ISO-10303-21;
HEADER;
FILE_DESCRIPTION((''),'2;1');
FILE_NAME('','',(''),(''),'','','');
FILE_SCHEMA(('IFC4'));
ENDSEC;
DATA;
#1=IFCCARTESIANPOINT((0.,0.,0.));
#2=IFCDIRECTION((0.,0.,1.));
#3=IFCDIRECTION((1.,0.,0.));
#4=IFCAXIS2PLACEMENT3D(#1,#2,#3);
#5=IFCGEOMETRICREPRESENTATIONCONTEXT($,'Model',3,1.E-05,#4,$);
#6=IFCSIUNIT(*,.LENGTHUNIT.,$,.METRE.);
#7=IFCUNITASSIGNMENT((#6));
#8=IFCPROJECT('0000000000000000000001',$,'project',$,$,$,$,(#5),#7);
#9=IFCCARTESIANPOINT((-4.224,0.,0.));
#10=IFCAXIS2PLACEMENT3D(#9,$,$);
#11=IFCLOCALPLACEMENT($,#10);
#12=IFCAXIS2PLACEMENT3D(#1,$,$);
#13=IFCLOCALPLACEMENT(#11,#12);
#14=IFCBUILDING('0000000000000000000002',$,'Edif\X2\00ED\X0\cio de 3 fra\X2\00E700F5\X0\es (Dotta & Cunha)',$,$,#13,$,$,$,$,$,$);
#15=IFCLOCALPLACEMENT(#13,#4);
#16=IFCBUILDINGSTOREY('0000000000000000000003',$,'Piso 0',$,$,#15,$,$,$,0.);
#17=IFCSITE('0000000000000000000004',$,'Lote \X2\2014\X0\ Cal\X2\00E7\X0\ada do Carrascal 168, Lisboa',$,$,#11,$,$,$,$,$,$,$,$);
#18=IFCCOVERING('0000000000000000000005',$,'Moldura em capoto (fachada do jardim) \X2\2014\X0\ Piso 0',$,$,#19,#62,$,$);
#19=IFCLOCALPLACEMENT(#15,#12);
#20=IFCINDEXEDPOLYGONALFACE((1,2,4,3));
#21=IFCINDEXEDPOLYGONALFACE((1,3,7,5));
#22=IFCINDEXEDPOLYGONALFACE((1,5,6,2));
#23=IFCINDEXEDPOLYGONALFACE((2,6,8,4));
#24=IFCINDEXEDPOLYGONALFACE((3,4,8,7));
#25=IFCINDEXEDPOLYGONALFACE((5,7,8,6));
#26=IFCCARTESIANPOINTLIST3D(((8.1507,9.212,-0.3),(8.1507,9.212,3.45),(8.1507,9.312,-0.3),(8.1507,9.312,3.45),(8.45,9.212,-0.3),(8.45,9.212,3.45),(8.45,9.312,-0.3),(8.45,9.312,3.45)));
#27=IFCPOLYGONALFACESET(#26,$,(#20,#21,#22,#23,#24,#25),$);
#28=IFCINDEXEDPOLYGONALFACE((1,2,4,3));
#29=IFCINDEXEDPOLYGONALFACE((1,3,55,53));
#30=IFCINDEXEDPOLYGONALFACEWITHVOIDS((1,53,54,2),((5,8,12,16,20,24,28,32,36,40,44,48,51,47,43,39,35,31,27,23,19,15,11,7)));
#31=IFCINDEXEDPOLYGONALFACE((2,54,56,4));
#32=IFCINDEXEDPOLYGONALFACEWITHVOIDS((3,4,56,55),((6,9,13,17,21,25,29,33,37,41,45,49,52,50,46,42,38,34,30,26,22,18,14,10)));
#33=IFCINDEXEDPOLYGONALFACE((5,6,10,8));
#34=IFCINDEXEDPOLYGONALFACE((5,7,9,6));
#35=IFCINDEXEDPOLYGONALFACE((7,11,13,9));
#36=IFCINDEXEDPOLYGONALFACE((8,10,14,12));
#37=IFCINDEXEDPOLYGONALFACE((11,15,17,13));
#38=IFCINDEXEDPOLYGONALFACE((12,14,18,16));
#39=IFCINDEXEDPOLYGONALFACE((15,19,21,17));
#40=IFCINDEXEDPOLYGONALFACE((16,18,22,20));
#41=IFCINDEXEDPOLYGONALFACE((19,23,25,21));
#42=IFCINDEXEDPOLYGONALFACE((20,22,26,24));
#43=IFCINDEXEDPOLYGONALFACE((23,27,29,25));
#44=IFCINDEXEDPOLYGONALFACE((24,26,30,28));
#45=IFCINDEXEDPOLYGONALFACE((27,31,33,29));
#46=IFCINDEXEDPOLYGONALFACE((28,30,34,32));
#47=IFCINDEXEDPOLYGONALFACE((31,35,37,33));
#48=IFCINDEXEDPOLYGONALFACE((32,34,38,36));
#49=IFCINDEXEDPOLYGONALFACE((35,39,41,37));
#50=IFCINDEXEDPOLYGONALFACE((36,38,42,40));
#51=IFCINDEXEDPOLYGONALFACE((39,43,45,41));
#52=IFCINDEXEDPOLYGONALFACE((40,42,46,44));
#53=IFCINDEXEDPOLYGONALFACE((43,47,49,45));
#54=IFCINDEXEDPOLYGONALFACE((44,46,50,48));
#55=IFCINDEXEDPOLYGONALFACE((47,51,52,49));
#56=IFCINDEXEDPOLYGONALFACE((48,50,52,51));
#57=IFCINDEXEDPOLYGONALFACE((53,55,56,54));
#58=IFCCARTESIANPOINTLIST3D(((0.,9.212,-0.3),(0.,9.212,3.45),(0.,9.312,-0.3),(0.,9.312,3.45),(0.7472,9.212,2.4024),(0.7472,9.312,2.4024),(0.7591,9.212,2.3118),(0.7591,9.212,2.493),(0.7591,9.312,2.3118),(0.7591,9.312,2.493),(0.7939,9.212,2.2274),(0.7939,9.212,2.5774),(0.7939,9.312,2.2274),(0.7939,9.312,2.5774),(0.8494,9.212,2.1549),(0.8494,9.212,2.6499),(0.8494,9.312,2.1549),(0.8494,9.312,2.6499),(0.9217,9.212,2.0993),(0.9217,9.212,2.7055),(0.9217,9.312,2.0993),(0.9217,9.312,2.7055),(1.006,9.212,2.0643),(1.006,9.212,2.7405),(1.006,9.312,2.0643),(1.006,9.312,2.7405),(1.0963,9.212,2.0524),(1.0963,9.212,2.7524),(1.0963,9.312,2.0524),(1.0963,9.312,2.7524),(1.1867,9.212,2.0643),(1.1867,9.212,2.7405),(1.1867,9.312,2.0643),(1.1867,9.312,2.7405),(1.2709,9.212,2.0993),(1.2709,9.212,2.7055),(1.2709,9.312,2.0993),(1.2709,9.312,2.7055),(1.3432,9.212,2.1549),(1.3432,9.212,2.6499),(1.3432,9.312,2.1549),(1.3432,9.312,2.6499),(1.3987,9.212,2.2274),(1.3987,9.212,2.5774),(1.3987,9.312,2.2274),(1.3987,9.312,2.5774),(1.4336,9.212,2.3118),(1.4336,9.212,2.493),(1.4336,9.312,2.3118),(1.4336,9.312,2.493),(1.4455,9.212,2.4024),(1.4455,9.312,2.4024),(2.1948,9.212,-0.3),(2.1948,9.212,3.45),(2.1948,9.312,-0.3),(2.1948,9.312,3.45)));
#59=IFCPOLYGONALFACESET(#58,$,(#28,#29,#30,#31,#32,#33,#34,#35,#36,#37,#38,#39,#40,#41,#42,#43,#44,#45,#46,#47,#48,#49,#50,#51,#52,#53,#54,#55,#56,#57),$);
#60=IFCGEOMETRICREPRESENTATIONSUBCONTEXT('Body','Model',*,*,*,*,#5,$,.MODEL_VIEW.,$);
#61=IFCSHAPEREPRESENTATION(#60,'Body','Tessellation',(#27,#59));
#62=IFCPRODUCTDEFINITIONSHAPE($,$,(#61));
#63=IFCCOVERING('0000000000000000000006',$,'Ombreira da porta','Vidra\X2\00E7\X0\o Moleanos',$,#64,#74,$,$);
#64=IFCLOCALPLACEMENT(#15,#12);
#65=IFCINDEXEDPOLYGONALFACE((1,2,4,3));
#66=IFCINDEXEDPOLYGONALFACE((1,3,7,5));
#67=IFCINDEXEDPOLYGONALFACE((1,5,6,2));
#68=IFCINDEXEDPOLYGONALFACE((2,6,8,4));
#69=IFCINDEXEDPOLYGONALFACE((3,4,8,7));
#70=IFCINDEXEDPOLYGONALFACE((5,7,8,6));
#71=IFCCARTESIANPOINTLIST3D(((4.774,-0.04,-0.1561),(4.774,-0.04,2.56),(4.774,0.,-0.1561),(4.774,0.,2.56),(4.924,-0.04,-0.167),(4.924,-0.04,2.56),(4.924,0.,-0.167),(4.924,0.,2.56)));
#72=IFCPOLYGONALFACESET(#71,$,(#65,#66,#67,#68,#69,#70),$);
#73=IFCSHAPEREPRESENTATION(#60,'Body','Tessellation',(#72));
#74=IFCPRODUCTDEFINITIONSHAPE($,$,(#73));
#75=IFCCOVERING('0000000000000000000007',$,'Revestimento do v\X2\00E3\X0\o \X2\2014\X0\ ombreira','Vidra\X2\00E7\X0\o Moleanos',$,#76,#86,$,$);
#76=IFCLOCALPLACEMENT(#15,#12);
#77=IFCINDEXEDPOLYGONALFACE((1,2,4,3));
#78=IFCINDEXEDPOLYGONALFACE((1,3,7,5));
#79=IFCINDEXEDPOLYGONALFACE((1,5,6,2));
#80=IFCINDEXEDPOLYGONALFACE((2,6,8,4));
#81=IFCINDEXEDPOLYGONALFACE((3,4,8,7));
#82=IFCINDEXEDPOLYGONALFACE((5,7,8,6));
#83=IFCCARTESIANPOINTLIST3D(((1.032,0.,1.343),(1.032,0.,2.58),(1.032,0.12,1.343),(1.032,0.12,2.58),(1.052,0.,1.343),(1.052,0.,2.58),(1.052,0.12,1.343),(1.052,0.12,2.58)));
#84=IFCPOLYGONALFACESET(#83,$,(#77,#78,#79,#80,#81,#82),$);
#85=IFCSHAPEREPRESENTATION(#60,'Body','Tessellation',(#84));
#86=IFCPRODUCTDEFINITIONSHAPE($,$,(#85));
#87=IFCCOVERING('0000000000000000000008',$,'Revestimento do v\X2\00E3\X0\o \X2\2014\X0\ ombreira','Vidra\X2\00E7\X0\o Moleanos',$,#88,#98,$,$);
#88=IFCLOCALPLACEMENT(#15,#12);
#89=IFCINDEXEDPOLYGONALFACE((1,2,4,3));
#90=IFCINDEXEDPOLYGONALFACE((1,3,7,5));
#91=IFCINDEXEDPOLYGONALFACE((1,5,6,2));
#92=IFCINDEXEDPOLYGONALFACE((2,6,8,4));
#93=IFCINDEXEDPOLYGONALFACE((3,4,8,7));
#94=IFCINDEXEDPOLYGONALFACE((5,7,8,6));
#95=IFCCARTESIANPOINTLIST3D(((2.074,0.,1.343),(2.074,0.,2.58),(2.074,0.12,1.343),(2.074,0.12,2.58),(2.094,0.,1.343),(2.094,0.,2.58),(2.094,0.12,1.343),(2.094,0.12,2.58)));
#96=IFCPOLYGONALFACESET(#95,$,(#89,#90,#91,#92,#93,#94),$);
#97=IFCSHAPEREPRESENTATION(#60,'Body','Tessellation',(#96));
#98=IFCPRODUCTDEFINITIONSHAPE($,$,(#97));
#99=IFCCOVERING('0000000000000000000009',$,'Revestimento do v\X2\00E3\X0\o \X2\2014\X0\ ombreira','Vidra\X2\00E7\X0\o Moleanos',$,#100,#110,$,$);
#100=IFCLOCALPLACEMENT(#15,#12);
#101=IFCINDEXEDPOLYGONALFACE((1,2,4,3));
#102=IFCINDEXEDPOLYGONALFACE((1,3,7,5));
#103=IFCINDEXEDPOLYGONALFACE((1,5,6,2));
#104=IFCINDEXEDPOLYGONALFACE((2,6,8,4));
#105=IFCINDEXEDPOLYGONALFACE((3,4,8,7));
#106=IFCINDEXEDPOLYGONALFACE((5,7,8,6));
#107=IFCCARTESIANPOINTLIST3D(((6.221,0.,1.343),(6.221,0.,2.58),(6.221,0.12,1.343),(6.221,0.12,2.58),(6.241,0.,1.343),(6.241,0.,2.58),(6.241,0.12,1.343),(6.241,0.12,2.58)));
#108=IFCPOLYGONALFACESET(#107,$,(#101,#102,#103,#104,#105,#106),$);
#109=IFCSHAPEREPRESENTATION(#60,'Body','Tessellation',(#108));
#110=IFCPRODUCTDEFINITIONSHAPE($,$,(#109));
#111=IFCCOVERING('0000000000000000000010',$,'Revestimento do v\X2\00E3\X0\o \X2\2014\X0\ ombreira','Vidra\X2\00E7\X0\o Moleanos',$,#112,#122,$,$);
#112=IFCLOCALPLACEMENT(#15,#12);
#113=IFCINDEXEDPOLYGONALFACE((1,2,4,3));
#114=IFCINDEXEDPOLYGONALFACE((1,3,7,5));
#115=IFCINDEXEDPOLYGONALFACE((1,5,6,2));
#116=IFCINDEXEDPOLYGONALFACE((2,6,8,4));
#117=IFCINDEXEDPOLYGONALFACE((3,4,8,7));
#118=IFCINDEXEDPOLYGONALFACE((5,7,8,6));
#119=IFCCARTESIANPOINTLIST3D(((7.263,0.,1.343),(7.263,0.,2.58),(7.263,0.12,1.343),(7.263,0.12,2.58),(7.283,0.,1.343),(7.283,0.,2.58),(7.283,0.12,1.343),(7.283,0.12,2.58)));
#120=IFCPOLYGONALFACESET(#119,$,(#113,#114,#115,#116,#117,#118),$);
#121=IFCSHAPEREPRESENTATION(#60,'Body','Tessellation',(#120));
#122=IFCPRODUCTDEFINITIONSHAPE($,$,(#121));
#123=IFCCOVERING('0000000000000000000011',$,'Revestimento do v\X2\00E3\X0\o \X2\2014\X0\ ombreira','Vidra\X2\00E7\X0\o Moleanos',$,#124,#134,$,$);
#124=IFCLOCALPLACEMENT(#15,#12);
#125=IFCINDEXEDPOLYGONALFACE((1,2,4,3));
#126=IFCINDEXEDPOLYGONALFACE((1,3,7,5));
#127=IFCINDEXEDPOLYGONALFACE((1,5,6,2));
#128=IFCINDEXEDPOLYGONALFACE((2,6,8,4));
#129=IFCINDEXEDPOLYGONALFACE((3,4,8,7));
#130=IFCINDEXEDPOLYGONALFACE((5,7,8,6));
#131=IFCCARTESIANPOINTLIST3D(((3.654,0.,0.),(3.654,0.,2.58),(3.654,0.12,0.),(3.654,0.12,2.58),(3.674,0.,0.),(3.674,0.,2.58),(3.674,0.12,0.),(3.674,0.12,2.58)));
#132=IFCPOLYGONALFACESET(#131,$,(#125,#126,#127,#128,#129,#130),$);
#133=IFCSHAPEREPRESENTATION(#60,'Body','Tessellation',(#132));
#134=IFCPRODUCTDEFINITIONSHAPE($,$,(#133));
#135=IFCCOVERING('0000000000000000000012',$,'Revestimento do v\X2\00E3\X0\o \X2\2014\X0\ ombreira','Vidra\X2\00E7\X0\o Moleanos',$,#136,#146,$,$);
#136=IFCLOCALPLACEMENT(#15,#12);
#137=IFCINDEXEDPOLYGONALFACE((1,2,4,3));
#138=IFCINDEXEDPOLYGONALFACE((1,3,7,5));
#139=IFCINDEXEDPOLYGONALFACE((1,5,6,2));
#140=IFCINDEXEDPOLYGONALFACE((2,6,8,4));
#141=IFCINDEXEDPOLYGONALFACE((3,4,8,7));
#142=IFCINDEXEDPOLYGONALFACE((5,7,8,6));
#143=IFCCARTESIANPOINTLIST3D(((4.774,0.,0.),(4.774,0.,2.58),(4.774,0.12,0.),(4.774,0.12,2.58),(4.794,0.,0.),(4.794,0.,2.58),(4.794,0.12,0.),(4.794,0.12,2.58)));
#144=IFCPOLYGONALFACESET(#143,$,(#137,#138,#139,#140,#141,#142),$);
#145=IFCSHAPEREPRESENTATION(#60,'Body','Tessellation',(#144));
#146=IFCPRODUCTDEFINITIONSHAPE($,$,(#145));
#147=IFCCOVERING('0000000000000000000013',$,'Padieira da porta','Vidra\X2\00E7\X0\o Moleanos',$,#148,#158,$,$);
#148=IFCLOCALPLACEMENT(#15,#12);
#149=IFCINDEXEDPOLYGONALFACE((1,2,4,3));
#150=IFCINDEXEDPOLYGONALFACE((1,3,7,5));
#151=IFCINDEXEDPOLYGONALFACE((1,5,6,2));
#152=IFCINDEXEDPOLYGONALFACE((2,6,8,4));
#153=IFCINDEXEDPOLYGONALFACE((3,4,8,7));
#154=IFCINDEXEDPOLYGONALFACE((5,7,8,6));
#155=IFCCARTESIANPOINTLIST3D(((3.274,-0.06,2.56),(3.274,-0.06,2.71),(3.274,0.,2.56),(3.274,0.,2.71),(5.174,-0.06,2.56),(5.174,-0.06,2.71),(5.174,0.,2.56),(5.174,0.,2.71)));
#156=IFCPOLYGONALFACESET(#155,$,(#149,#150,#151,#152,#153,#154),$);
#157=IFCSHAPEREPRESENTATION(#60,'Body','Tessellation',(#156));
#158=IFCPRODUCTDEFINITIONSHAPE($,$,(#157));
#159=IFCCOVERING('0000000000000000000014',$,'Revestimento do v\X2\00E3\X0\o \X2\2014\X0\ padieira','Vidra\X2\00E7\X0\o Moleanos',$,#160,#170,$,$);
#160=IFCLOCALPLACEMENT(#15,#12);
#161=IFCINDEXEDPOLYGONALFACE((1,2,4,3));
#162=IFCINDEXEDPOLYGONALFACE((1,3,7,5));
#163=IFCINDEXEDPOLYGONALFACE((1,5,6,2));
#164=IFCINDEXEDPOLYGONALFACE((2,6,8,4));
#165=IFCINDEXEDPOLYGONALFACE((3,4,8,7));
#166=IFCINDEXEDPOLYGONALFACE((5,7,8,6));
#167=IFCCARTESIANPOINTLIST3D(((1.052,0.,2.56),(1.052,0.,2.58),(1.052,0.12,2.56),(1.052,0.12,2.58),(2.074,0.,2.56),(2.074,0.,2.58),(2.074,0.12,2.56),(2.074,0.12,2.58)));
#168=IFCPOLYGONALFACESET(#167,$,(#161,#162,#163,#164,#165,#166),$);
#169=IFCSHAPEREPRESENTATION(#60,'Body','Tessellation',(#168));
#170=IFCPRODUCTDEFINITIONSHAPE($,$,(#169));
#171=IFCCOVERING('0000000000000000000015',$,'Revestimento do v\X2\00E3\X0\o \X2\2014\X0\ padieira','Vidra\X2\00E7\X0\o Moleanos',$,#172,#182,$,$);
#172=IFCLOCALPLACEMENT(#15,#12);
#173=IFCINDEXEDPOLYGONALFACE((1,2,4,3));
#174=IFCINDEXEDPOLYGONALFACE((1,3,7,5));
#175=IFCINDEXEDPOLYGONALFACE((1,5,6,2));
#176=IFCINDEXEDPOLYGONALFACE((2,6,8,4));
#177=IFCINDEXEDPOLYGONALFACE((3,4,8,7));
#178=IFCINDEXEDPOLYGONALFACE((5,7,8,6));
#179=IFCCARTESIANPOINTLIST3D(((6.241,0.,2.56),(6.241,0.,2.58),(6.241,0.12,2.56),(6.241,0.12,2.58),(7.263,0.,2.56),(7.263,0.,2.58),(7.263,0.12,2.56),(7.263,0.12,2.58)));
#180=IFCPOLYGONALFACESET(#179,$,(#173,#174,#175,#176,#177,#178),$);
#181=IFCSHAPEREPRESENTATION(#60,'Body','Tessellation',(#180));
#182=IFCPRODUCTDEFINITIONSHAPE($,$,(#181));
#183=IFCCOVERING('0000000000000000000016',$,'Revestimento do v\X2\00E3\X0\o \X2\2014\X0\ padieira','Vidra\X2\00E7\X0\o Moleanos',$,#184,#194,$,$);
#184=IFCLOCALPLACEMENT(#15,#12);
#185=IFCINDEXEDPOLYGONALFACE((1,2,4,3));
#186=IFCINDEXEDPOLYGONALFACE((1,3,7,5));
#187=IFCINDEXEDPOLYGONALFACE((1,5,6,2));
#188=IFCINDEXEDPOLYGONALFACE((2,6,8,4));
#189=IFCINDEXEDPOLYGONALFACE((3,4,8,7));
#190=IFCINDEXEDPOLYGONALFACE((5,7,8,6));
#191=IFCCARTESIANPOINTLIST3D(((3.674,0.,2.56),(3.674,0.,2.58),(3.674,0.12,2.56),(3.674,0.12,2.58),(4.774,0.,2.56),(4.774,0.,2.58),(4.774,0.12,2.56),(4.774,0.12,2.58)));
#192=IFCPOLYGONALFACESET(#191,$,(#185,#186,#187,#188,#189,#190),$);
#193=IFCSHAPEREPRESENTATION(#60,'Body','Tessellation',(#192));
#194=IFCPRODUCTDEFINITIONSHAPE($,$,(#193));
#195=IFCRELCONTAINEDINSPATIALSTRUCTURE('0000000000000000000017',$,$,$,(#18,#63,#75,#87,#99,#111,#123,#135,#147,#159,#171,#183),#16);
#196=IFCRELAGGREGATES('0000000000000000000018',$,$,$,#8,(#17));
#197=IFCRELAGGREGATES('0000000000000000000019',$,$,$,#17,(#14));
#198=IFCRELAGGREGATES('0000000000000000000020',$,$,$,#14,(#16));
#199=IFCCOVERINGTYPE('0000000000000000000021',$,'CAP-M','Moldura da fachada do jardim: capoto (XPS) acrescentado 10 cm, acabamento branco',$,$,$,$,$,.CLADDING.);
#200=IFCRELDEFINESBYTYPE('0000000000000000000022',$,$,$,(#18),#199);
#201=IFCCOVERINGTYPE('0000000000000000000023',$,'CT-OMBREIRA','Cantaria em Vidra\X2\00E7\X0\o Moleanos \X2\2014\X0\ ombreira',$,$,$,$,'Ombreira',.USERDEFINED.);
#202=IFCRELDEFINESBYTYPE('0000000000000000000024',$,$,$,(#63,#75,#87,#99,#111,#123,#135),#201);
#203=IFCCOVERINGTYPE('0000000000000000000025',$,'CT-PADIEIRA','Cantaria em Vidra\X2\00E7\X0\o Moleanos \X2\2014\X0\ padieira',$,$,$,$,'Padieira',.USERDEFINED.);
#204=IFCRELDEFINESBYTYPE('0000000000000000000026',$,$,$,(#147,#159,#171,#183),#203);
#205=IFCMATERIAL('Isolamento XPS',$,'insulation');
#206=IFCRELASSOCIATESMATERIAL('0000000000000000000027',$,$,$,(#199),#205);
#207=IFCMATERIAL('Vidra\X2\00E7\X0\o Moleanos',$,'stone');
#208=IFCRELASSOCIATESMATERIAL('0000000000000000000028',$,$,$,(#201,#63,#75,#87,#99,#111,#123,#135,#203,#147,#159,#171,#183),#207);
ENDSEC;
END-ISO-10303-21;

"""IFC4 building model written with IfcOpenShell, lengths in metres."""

from ifc_helpers import new_model, si_unit, frame, origin, origin_with_axes, place, context, subcontext, project, spatial, line, indexed_curve, outline, extrude, material, type_object, element, save


model = new_model("IFC4")

# Units and contexts
model_context = context("Model", 3, precision=1e-05, world=origin_with_axes())
body_context = subcontext(model_context, "Body", "Model", "MODEL_VIEW")
ifc_project = project(units=[si_unit("LENGTHUNIT", "METRE")], contexts=[model_context])

# Site, building, storey
site_placement = place(None, frame((-4.224, 0.0, 0.0)))
site = spatial("IfcSite", under=ifc_project, at=site_placement, Name="Lote — Calçada do Carrascal 168, Lisboa")
building_placement = place(site_placement, origin())
building = spatial("IfcBuilding", under=site, at=building_placement, Name="Edifício de 3 frações (Dotta & Cunha)")
storey_placement = place(building_placement, origin_with_axes())
storey = spatial("IfcBuildingStorey", under=building, at=storey_placement, Name="Piso 0", Elevation=0.0)

# Covering
ifc_material_1 = material(Name="Isolamento XPS", Category="insulation")
covering_type_1 = type_object("IfcCoveringType", Name="CAP-M", Description="Moldura da fachada do jardim: capoto (XPS) acrescentado 10 cm, acabamento branco", PredefinedType="CLADDING", material=ifc_material_1)
covering_1_placement = place(storey_placement, frame((0.0, 9.312, 0.0), z_axis=(0.0, -1.0, 0.0), x_axis=(1.0, 0.0, 0.0)))
element("IfcCovering", 1, at=covering_1_placement, inside=storey, type_object=covering_type_1, Name="Moldura em capoto (fachada do jardim) — Piso 0", context=body_context, shape_type="SweptSolid", body=[
    extrude(outline(indexed_curve([(8.45, -0.3), (8.1507, -0.3), (8.1507, 3.45), (8.45, 3.45)], segments=[line(1, 2, 3, 4, 1)])), origin_with_axes(), (0.0, 0.0, 1.0), 0.1),
    extrude(outline(indexed_curve([(2.1948, -0.3), (0.0, -0.3), (0.0, 3.45), (2.1948, 3.45)], segments=[line(1, 2, 3, 4, 1)]), holes=[indexed_curve([(0.9217, 2.7055), (0.8494, 2.6499), (0.7939, 2.5774), (0.7591, 2.493), (0.7472, 2.4024), (0.7591, 2.3118), (0.7939, 2.2274), (0.8494, 2.1549), (0.9217, 2.0993), (1.006, 2.0643), (1.0963, 2.0524), (1.1867, 2.0643), (1.2709, 2.0993), (1.3432, 2.1549), (1.3987, 2.2274), (1.4336, 2.3118), (1.4455, 2.4024), (1.4336, 2.493), (1.3987, 2.5774), (1.3432, 2.6499), (1.2709, 2.7055), (1.1867, 2.7405), (1.0963, 2.7524), (1.006, 2.7405)], segments=[line(1, 2, 3, 4, 5, 6, 7, 8, 9, 10, 11, 12, 13, 14, 15, 16, 17, 18, 19, 20, 21, 22, 23, 24, 1)])]), origin_with_axes(), (0.0, 0.0, 1.0), 0.1),
])

# Coverings
ifc_material_2 = material(Name="Vidraço Moleanos", Category="stone")
covering_type_2 = type_object("IfcCoveringType", Name="CT-OMBREIRA", Description="Cantaria em Vidraço Moleanos — ombreira", ElementType="Ombreira", PredefinedType="USERDEFINED", material=ifc_material_2)
covering_2_placement = place(storey_placement, frame((0.0, 0.0, 0.0), z_axis=(0.0, -1.0, 0.0), x_axis=(1.0, 0.0, 0.0)))
element("IfcCovering", 2, at=covering_2_placement, inside=storey, type_object=covering_type_2, material=ifc_material_2, Name="Ombreira da porta", Description="Vidraço Moleanos", context=body_context, shape_type="SweptSolid", body=[
    extrude(outline(indexed_curve([(4.774, -0.1561), (4.924, -0.167), (4.924, 2.56), (4.774, 2.56)], segments=[line(1, 2, 3, 4, 1)])), origin_with_axes(), (0.0, 0.0, 1.0), 0.04),
])
covering_3_placement = place(storey_placement, frame((0.0, 0.12, 0.0), z_axis=(0.0, -1.0, 0.0), x_axis=(1.0, 0.0, 0.0)))
element("IfcCovering", 3, at=covering_3_placement, inside=storey, type_object=covering_type_2, material=ifc_material_2, Name="Revestimento do vão — ombreira", Description="Vidraço Moleanos", context=body_context, shape_type="SweptSolid", body=[
    extrude(outline(indexed_curve([(1.052, 1.343), (1.052, 2.58), (1.032, 2.58), (1.032, 1.343)], segments=[line(1, 2, 3, 4, 1)])), origin_with_axes(), (0.0, 0.0, 1.0), 0.12),
])
covering_4_placement = place(storey_placement, frame((0.0, 0.12, 0.0), z_axis=(0.0, -1.0, 0.0), x_axis=(1.0, 0.0, 0.0)))
element("IfcCovering", 4, at=covering_4_placement, inside=storey, type_object=covering_type_2, material=ifc_material_2, Name="Revestimento do vão — ombreira", Description="Vidraço Moleanos", context=body_context, shape_type="SweptSolid", body=[
    extrude(outline(indexed_curve([(2.094, 1.343), (2.094, 2.58), (2.074, 2.58), (2.074, 1.343)], segments=[line(1, 2, 3, 4, 1)])), origin_with_axes(), (0.0, 0.0, 1.0), 0.12),
])
covering_5_placement = place(storey_placement, frame((0.0, 0.12, 0.0), z_axis=(0.0, -1.0, 0.0), x_axis=(1.0, 0.0, 0.0)))
element("IfcCovering", 5, at=covering_5_placement, inside=storey, type_object=covering_type_2, material=ifc_material_2, Name="Revestimento do vão — ombreira", Description="Vidraço Moleanos", context=body_context, shape_type="SweptSolid", body=[
    extrude(outline(indexed_curve([(6.241, 1.343), (6.241, 2.58), (6.221, 2.58), (6.221, 1.343)], segments=[line(1, 2, 3, 4, 1)])), origin_with_axes(), (0.0, 0.0, 1.0), 0.12),
])
covering_6_placement = place(storey_placement, frame((0.0, 0.12, 0.0), z_axis=(0.0, -1.0, 0.0), x_axis=(1.0, 0.0, 0.0)))
element("IfcCovering", 6, at=covering_6_placement, inside=storey, type_object=covering_type_2, material=ifc_material_2, Name="Revestimento do vão — ombreira", Description="Vidraço Moleanos", context=body_context, shape_type="SweptSolid", body=[
    extrude(outline(indexed_curve([(7.283, 1.343), (7.283, 2.58), (7.263, 2.58), (7.263, 1.343)], segments=[line(1, 2, 3, 4, 1)])), origin_with_axes(), (0.0, 0.0, 1.0), 0.12),
])
covering_7_placement = place(storey_placement, frame((0.0, 0.12, 0.0), z_axis=(0.0, -1.0, 0.0), x_axis=(1.0, 0.0, 0.0)))
element("IfcCovering", 7, at=covering_7_placement, inside=storey, type_object=covering_type_2, material=ifc_material_2, Name="Revestimento do vão — ombreira", Description="Vidraço Moleanos", context=body_context, shape_type="SweptSolid", body=[
    extrude(outline(indexed_curve([(3.674, 0.0), (3.674, 2.58), (3.654, 2.58), (3.654, 0.0)], segments=[line(1, 2, 3, 4, 1)])), origin_with_axes(), (0.0, 0.0, 1.0), 0.12),
])
covering_8_placement = place(storey_placement, frame((0.0, 0.12, 0.0), z_axis=(0.0, -1.0, 0.0), x_axis=(1.0, 0.0, 0.0)))
element("IfcCovering", 8, at=covering_8_placement, inside=storey, type_object=covering_type_2, material=ifc_material_2, Name="Revestimento do vão — ombreira", Description="Vidraço Moleanos", context=body_context, shape_type="SweptSolid", body=[
    extrude(outline(indexed_curve([(4.794, 0.0), (4.794, 2.58), (4.774, 2.58), (4.774, 0.0)], segments=[line(1, 2, 3, 4, 1)])), origin_with_axes(), (0.0, 0.0, 1.0), 0.12),
])
covering_type_3 = type_object("IfcCoveringType", Name="CT-PADIEIRA", Description="Cantaria em Vidraço Moleanos — padieira", ElementType="Padieira", PredefinedType="USERDEFINED", material=ifc_material_2)
covering_9_placement = place(storey_placement, frame((0.0, 0.0, 0.0), z_axis=(0.0, -1.0, 0.0), x_axis=(1.0, 0.0, 0.0)))
element("IfcCovering", 9, at=covering_9_placement, inside=storey, type_object=covering_type_3, material=ifc_material_2, Name="Padieira da porta", Description="Vidraço Moleanos", context=body_context, shape_type="SweptSolid", body=[
    extrude(outline(indexed_curve([(5.174, 2.56), (5.174, 2.71), (3.274, 2.71), (3.274, 2.56)], segments=[line(1, 2, 3, 4, 1)])), origin_with_axes(), (0.0, 0.0, 1.0), 0.06),
])
covering_10_placement = place(storey_placement, frame((0.0, 0.12, 0.0), z_axis=(0.0, -1.0, 0.0), x_axis=(1.0, 0.0, 0.0)))
element("IfcCovering", 10, at=covering_10_placement, inside=storey, type_object=covering_type_3, material=ifc_material_2, Name="Revestimento do vão — padieira", Description="Vidraço Moleanos", context=body_context, shape_type="SweptSolid", body=[
    extrude(outline(indexed_curve([(2.074, 2.56), (2.074, 2.58), (1.052, 2.58), (1.052, 2.56)], segments=[line(1, 2, 3, 4, 1)])), origin_with_axes(), (0.0, 0.0, 1.0), 0.12),
])
covering_11_placement = place(storey_placement, frame((0.0, 0.12, 0.0), z_axis=(0.0, -1.0, 0.0), x_axis=(1.0, 0.0, 0.0)))
element("IfcCovering", 11, at=covering_11_placement, inside=storey, type_object=covering_type_3, material=ifc_material_2, Name="Revestimento do vão — padieira", Description="Vidraço Moleanos", context=body_context, shape_type="SweptSolid", body=[
    extrude(outline(indexed_curve([(7.263, 2.56), (7.263, 2.58), (6.241, 2.58), (6.241, 2.56)], segments=[line(1, 2, 3, 4, 1)])), origin_with_axes(), (0.0, 0.0, 1.0), 0.12),
])
covering_12_placement = place(storey_placement, frame((0.0, 0.12, 0.0), z_axis=(0.0, -1.0, 0.0), x_axis=(1.0, 0.0, 0.0)))
element("IfcCovering", 12, at=covering_12_placement, inside=storey, type_object=covering_type_3, material=ifc_material_2, Name="Revestimento do vão — padieira", Description="Vidraço Moleanos", context=body_context, shape_type="SweptSolid", body=[
    extrude(outline(indexed_curve([(4.774, 2.56), (4.774, 2.58), (3.674, 2.58), (3.674, 2.56)], segments=[line(1, 2, 3, 4, 1)])), origin_with_axes(), (0.0, 0.0, 1.0), 0.12),
])

save(model, "model.ifc")
